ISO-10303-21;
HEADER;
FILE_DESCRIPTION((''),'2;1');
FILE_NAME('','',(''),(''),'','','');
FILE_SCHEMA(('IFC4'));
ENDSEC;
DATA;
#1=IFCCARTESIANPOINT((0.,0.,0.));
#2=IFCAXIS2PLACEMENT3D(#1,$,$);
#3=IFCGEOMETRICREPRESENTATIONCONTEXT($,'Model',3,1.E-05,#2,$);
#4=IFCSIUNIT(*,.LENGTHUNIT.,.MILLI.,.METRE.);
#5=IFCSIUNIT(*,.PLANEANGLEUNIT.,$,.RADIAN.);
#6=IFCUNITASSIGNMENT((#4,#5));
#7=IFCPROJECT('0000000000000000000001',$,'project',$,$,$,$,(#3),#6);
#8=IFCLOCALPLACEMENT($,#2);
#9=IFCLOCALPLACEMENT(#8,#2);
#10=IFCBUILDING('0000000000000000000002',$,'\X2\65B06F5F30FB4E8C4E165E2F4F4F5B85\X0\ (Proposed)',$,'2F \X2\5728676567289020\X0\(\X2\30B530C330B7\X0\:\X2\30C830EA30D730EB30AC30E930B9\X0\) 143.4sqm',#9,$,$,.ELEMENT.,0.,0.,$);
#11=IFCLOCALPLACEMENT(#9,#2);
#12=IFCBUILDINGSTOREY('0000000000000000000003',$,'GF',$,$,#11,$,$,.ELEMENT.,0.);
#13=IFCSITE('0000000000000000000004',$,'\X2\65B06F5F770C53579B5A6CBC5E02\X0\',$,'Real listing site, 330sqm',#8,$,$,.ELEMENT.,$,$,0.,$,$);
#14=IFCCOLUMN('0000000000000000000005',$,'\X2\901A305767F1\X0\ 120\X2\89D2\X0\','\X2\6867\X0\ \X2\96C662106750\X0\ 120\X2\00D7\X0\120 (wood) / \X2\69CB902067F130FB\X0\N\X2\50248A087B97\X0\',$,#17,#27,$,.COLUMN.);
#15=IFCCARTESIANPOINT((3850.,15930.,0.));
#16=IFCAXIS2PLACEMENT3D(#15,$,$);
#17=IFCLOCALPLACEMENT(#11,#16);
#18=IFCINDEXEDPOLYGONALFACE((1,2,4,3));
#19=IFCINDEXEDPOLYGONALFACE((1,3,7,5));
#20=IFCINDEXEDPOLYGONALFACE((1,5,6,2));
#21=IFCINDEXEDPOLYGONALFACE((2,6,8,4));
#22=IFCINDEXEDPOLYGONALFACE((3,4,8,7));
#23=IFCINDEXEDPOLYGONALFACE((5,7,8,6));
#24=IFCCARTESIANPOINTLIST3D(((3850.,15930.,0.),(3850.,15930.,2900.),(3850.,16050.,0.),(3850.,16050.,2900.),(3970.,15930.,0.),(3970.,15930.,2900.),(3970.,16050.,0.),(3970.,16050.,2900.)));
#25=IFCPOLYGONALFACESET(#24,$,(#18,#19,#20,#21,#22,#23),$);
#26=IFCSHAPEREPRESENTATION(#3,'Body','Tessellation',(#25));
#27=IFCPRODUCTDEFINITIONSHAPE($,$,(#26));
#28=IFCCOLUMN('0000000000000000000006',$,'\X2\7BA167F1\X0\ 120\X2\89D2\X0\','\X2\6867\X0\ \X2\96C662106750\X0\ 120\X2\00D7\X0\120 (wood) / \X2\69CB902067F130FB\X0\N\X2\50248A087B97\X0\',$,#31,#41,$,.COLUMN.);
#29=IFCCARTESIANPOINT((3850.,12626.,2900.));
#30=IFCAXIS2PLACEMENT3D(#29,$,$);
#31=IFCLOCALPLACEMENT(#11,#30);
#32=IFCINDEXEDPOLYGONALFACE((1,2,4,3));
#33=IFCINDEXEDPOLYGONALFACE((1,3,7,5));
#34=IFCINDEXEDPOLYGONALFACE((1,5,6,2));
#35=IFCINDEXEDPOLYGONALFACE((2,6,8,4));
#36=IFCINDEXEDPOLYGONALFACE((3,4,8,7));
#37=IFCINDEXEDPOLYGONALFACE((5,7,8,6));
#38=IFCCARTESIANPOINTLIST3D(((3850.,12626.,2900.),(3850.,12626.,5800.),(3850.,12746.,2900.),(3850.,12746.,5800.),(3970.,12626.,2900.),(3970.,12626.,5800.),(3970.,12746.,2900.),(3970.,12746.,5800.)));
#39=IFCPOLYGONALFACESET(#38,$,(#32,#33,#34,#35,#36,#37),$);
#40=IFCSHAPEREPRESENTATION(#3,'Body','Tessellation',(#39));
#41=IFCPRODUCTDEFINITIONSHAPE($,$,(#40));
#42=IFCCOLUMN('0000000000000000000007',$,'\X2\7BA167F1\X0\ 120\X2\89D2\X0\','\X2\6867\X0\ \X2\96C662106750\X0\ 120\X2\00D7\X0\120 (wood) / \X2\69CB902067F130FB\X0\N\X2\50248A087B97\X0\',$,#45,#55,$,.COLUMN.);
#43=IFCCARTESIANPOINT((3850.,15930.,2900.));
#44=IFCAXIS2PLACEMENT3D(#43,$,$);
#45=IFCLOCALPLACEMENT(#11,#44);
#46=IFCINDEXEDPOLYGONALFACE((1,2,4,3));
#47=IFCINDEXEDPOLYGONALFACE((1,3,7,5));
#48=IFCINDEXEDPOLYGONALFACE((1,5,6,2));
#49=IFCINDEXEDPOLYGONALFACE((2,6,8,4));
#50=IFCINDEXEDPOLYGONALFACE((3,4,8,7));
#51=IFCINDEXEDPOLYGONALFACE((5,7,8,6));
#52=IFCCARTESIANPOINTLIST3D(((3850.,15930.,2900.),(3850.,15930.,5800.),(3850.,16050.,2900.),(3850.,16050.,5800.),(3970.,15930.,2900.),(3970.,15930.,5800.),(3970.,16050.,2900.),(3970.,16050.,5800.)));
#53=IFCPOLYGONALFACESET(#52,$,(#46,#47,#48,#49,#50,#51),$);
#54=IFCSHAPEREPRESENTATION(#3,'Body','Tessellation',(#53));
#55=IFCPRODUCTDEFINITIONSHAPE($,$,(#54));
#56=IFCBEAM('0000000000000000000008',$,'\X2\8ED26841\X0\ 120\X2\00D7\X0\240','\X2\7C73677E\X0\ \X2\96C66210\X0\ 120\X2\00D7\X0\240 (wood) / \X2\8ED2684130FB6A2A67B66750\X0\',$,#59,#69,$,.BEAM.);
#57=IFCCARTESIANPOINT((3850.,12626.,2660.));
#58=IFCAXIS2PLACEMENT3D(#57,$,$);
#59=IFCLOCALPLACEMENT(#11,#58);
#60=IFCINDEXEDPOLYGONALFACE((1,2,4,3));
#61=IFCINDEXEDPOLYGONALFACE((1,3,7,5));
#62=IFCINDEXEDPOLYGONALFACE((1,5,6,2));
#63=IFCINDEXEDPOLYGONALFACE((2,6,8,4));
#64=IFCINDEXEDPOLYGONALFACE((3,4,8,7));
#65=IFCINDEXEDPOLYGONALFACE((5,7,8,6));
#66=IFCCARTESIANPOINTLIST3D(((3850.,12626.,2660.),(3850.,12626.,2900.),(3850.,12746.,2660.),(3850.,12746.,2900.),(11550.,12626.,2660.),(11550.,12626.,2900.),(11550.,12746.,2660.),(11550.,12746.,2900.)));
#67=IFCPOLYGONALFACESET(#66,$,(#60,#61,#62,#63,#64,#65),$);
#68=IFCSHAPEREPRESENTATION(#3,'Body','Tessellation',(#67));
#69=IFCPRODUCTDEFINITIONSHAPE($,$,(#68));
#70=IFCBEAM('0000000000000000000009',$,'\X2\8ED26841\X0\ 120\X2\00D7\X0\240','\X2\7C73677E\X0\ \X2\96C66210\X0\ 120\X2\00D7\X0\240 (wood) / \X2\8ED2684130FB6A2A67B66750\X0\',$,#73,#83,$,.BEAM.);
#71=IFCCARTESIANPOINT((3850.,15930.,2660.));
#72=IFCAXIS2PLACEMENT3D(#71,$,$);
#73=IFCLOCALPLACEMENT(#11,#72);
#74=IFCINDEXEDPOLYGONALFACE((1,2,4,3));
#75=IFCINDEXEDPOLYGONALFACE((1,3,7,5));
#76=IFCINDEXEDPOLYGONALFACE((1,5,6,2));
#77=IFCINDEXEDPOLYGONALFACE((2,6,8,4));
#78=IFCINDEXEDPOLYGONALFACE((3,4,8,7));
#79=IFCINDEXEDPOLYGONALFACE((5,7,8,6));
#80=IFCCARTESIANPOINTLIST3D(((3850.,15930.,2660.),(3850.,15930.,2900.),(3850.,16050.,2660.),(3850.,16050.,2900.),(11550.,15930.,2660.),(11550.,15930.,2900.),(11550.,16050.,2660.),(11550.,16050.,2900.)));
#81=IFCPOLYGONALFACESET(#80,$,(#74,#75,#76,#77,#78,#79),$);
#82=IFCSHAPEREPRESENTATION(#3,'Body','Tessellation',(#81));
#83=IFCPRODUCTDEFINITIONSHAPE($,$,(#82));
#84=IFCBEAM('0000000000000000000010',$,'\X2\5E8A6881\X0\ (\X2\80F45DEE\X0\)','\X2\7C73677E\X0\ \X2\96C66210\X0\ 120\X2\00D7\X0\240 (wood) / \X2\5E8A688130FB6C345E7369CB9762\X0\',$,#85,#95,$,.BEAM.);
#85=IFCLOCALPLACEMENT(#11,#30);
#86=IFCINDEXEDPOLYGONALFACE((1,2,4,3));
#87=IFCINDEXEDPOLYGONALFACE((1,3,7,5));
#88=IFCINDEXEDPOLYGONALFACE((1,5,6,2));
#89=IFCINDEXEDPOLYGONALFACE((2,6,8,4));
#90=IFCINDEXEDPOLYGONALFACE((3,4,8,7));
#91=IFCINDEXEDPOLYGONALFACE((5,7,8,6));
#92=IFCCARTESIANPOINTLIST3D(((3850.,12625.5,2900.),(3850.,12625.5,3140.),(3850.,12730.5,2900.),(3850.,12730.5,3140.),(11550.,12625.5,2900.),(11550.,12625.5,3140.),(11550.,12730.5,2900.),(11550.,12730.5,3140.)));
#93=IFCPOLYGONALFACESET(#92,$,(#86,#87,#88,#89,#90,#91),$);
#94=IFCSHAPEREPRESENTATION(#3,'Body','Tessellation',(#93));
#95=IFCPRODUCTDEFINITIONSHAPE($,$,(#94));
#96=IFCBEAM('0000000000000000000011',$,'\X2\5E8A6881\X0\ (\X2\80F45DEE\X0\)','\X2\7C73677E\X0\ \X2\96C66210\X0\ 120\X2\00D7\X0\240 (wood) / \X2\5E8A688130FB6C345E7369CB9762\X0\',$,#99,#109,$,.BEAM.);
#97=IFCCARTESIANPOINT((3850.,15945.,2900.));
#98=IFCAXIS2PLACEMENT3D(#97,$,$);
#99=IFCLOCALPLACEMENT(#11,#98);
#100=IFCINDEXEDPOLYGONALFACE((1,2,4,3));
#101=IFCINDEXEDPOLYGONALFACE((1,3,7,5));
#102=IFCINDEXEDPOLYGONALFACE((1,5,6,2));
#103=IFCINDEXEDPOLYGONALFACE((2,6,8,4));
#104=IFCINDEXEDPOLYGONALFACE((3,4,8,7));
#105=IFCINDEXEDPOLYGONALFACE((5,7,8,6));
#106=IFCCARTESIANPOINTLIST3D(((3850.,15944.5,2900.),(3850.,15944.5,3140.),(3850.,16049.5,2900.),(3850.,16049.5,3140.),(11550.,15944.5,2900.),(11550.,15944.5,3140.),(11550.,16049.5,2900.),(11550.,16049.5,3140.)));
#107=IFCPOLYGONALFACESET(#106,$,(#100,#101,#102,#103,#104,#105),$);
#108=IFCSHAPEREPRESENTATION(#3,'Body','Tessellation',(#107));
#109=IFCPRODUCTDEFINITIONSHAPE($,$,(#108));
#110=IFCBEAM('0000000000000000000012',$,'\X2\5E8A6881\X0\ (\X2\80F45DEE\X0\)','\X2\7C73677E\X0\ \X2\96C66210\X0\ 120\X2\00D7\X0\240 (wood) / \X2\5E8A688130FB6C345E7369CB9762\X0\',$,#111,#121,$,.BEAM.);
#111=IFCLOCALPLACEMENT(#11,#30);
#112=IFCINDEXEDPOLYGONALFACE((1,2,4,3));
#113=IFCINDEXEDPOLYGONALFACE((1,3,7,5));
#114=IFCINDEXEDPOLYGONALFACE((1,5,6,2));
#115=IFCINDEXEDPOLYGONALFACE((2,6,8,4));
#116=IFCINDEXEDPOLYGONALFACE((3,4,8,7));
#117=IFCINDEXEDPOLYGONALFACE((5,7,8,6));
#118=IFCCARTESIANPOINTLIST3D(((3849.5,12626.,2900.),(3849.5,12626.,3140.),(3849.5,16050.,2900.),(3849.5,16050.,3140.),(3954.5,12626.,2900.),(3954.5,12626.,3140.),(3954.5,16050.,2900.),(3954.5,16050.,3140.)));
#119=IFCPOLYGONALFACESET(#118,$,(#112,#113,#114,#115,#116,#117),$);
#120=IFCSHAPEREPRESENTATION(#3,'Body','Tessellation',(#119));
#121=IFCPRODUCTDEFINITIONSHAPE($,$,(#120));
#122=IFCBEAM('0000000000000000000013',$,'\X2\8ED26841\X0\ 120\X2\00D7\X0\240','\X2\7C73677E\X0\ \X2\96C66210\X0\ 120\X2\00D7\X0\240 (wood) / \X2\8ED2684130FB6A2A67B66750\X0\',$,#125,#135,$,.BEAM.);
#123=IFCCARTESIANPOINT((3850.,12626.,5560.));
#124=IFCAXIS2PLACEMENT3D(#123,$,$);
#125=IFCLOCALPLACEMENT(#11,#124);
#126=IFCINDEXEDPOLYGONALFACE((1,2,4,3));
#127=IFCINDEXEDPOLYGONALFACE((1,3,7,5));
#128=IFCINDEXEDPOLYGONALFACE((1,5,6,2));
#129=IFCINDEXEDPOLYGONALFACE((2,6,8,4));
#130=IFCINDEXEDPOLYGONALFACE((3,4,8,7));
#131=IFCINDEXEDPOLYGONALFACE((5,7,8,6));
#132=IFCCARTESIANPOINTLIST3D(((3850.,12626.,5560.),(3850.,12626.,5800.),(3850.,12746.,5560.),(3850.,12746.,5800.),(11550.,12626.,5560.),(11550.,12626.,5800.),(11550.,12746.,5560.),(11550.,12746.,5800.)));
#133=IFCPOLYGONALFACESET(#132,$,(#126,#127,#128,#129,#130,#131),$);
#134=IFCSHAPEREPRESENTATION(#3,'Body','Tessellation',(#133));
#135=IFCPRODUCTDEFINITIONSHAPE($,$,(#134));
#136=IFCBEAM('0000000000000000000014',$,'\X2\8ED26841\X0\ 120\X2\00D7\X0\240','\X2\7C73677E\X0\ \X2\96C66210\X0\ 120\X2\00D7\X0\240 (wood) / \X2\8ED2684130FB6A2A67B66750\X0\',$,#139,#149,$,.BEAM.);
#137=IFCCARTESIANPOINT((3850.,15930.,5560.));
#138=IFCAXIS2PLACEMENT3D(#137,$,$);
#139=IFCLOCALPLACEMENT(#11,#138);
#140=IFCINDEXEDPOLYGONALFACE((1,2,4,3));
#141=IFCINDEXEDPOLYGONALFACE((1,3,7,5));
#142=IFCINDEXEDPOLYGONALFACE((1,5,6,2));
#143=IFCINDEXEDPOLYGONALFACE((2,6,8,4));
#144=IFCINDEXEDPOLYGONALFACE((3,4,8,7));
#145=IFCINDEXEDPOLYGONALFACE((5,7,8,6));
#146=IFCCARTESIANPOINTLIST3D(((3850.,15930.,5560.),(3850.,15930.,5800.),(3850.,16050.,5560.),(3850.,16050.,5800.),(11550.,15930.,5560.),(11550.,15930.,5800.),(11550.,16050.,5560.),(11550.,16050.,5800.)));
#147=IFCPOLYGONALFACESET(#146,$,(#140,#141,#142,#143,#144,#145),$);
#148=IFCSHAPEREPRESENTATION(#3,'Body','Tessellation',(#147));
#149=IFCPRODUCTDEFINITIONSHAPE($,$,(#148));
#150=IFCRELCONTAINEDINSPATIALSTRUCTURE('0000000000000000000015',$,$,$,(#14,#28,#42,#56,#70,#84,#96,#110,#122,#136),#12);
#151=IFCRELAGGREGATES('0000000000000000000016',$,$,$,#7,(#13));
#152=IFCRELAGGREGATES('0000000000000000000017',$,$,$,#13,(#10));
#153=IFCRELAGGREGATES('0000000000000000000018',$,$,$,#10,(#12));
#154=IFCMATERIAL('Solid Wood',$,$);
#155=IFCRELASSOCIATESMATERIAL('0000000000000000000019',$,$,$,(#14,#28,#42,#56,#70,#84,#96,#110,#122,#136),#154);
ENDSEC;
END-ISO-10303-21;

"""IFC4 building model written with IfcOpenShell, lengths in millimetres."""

from ifc_helpers import new_model, si_unit, frame, frame_2d, origin, place, context, project, spatial, rectangle, extrude, material, element, save


model = new_model("IFC4")

# Units and contexts
model_context = context("Model", 3, precision=1e-05, world=origin())
ifc_project = project(units=[si_unit("LENGTHUNIT", "METRE", prefix="MILLI"), si_unit("PLANEANGLEUNIT", "RADIAN")], contexts=[model_context])

# Site, building, storey
site_placement = place(None, origin())
site = spatial("IfcSite", under=ifc_project, at=site_placement, Name="新潟県南魚沼市", ObjectType="Real listing site, 330sqm", CompositionType="ELEMENT", RefElevation=0.0)
building_placement = place(site_placement, origin())
building = spatial("IfcBuilding", under=site, at=building_placement, Name="新潟・二世帯住宅 (Proposed)", ObjectType="2F 在来木造(サッシ:トリプルガラス) 143.4sqm", CompositionType="ELEMENT", ElevationOfRefHeight=0.0, ElevationOfTerrain=0.0)
storey_placement = place(building_placement, origin())
storey = spatial("IfcBuildingStorey", under=building, at=storey_placement, Name="GF", CompositionType="ELEMENT", Elevation=0.0)

# Columns
ifc_material_1 = material(Name="Solid Wood")
column_1_placement = place(storey_placement, frame((3850.0, 15930.0, 0.0)))
element("IfcColumn", 1, at=column_1_placement, inside=storey, material=ifc_material_1, Name="通し柱 120角", Description="桧 集成材 120×120 (wood) / 構造柱・N値計算", PredefinedType="COLUMN", context=model_context, shape_type="SweptSolid", body=[
    extrude(rectangle(XDim=120.0, YDim=120.0, at=frame_2d((60.0, 60.0))), frame((3850.0, 15930.0, 0.0)), (0.0, 0.0, 1.0), 2900.0),
])
column_2_placement = place(storey_placement, frame((3850.0, 12626.0, 2900.0)))
element("IfcColumn", 2, at=column_2_placement, inside=storey, material=ifc_material_1, Name="管柱 120角", Description="桧 集成材 120×120 (wood) / 構造柱・N値計算", PredefinedType="COLUMN", context=model_context, shape_type="SweptSolid", body=[
    extrude(rectangle(XDim=120.0, YDim=120.0, at=frame_2d((60.0, 60.0))), frame((3850.0, 12626.0, 2900.0)), (0.0, 0.0, 1.0), 2900.0),
])
column_3_placement = place(storey_placement, frame((3850.0, 15930.0, 2900.0)))
element("IfcColumn", 3, at=column_3_placement, inside=storey, material=ifc_material_1, Name="管柱 120角", Description="桧 集成材 120×120 (wood) / 構造柱・N値計算", PredefinedType="COLUMN", context=model_context, shape_type="SweptSolid", body=[
    extrude(rectangle(XDim=120.0, YDim=120.0, at=frame_2d((60.0, 60.0))), frame((3850.0, 15930.0, 2900.0)), (0.0, 0.0, 1.0), 2900.0),
])

# Beams
beam_1_placement = place(storey_placement, frame((3850.0, 12626.0, 2660.0)))
element("IfcBeam", 4, at=beam_1_placement, inside=storey, material=ifc_material_1, Name="軒桁 120×240", Description="米松 集成 120×240 (wood) / 軒桁・横架材", PredefinedType="BEAM", context=model_context, shape_type="SweptSolid", body=[
    extrude(rectangle(XDim=7700.0, YDim=120.0, at=frame_2d((3850.0, 60.0))), frame((3850.0, 12626.0, 2660.0)), (0.0, 0.0, 1.0), 240.0),
])
beam_2_placement = place(storey_placement, frame((3850.0, 15930.0, 2660.0)))
element("IfcBeam", 5, at=beam_2_placement, inside=storey, material=ifc_material_1, Name="軒桁 120×240", Description="米松 集成 120×240 (wood) / 軒桁・横架材", PredefinedType="BEAM", context=model_context, shape_type="SweptSolid", body=[
    extrude(rectangle(XDim=7700.0, YDim=120.0, at=frame_2d((3850.0, 60.0))), frame((3850.0, 15930.0, 2660.0)), (0.0, 0.0, 1.0), 240.0),
])
beam_3_placement = place(storey_placement, frame((3850.0, 12626.0, 2900.0)))
element("IfcBeam", 6, at=beam_3_placement, inside=storey, material=ifc_material_1, Name="床梁 (胴差)", Description="米松 集成 120×240 (wood) / 床梁・水平構面", PredefinedType="BEAM", context=model_context, shape_type="SweptSolid", body=[
    extrude(rectangle(XDim=7700.0, YDim=105.0, at=frame_2d((3850.0, 52.0))), frame((3850.0, 12626.0, 2900.0)), (0.0, 0.0, 1.0), 240.0),
])
beam_4_placement = place(storey_placement, frame((3850.0, 15945.0, 2900.0)))
element("IfcBeam", 7, at=beam_4_placement, inside=storey, material=ifc_material_1, Name="床梁 (胴差)", Description="米松 集成 120×240 (wood) / 床梁・水平構面", PredefinedType="BEAM", context=model_context, shape_type="SweptSolid", body=[
    extrude(rectangle(XDim=7700.0, YDim=105.0, at=frame_2d((3850.0, 52.0))), frame((3850.0, 15945.0, 2900.0)), (0.0, 0.0, 1.0), 240.0),
])
beam_5_placement = place(storey_placement, frame((3850.0, 12626.0, 2900.0)))
element("IfcBeam", 8, at=beam_5_placement, inside=storey, material=ifc_material_1, Name="床梁 (胴差)", Description="米松 集成 120×240 (wood) / 床梁・水平構面", PredefinedType="BEAM", context=model_context, shape_type="SweptSolid", body=[
    extrude(rectangle(XDim=105.0, YDim=3424.0, at=frame_2d((52.0, 1712.0))), frame((3850.0, 12626.0, 2900.0)), (0.0, 0.0, 1.0), 240.0),
])
beam_6_placement = place(storey_placement, frame((3850.0, 12626.0, 5560.0)))
element("IfcBeam", 9, at=beam_6_placement, inside=storey, material=ifc_material_1, Name="軒桁 120×240", Description="米松 集成 120×240 (wood) / 軒桁・横架材", PredefinedType="BEAM", context=model_context, shape_type="SweptSolid", body=[
    extrude(rectangle(XDim=7700.0, YDim=120.0, at=frame_2d((3850.0, 60.0))), frame((3850.0, 12626.0, 5560.0)), (0.0, 0.0, 1.0), 240.0),
])
beam_7_placement = place(storey_placement, frame((3850.0, 15930.0, 5560.0)))
element("IfcBeam", 10, at=beam_7_placement, inside=storey, material=ifc_material_1, Name="軒桁 120×240", Description="米松 集成 120×240 (wood) / 軒桁・横架材", PredefinedType="BEAM", context=model_context, shape_type="SweptSolid", body=[
    extrude(rectangle(XDim=7700.0, YDim=120.0, at=frame_2d((3850.0, 60.0))), frame((3850.0, 15930.0, 5560.0)), (0.0, 0.0, 1.0), 240.0),
])

save(model, "model.ifc")
